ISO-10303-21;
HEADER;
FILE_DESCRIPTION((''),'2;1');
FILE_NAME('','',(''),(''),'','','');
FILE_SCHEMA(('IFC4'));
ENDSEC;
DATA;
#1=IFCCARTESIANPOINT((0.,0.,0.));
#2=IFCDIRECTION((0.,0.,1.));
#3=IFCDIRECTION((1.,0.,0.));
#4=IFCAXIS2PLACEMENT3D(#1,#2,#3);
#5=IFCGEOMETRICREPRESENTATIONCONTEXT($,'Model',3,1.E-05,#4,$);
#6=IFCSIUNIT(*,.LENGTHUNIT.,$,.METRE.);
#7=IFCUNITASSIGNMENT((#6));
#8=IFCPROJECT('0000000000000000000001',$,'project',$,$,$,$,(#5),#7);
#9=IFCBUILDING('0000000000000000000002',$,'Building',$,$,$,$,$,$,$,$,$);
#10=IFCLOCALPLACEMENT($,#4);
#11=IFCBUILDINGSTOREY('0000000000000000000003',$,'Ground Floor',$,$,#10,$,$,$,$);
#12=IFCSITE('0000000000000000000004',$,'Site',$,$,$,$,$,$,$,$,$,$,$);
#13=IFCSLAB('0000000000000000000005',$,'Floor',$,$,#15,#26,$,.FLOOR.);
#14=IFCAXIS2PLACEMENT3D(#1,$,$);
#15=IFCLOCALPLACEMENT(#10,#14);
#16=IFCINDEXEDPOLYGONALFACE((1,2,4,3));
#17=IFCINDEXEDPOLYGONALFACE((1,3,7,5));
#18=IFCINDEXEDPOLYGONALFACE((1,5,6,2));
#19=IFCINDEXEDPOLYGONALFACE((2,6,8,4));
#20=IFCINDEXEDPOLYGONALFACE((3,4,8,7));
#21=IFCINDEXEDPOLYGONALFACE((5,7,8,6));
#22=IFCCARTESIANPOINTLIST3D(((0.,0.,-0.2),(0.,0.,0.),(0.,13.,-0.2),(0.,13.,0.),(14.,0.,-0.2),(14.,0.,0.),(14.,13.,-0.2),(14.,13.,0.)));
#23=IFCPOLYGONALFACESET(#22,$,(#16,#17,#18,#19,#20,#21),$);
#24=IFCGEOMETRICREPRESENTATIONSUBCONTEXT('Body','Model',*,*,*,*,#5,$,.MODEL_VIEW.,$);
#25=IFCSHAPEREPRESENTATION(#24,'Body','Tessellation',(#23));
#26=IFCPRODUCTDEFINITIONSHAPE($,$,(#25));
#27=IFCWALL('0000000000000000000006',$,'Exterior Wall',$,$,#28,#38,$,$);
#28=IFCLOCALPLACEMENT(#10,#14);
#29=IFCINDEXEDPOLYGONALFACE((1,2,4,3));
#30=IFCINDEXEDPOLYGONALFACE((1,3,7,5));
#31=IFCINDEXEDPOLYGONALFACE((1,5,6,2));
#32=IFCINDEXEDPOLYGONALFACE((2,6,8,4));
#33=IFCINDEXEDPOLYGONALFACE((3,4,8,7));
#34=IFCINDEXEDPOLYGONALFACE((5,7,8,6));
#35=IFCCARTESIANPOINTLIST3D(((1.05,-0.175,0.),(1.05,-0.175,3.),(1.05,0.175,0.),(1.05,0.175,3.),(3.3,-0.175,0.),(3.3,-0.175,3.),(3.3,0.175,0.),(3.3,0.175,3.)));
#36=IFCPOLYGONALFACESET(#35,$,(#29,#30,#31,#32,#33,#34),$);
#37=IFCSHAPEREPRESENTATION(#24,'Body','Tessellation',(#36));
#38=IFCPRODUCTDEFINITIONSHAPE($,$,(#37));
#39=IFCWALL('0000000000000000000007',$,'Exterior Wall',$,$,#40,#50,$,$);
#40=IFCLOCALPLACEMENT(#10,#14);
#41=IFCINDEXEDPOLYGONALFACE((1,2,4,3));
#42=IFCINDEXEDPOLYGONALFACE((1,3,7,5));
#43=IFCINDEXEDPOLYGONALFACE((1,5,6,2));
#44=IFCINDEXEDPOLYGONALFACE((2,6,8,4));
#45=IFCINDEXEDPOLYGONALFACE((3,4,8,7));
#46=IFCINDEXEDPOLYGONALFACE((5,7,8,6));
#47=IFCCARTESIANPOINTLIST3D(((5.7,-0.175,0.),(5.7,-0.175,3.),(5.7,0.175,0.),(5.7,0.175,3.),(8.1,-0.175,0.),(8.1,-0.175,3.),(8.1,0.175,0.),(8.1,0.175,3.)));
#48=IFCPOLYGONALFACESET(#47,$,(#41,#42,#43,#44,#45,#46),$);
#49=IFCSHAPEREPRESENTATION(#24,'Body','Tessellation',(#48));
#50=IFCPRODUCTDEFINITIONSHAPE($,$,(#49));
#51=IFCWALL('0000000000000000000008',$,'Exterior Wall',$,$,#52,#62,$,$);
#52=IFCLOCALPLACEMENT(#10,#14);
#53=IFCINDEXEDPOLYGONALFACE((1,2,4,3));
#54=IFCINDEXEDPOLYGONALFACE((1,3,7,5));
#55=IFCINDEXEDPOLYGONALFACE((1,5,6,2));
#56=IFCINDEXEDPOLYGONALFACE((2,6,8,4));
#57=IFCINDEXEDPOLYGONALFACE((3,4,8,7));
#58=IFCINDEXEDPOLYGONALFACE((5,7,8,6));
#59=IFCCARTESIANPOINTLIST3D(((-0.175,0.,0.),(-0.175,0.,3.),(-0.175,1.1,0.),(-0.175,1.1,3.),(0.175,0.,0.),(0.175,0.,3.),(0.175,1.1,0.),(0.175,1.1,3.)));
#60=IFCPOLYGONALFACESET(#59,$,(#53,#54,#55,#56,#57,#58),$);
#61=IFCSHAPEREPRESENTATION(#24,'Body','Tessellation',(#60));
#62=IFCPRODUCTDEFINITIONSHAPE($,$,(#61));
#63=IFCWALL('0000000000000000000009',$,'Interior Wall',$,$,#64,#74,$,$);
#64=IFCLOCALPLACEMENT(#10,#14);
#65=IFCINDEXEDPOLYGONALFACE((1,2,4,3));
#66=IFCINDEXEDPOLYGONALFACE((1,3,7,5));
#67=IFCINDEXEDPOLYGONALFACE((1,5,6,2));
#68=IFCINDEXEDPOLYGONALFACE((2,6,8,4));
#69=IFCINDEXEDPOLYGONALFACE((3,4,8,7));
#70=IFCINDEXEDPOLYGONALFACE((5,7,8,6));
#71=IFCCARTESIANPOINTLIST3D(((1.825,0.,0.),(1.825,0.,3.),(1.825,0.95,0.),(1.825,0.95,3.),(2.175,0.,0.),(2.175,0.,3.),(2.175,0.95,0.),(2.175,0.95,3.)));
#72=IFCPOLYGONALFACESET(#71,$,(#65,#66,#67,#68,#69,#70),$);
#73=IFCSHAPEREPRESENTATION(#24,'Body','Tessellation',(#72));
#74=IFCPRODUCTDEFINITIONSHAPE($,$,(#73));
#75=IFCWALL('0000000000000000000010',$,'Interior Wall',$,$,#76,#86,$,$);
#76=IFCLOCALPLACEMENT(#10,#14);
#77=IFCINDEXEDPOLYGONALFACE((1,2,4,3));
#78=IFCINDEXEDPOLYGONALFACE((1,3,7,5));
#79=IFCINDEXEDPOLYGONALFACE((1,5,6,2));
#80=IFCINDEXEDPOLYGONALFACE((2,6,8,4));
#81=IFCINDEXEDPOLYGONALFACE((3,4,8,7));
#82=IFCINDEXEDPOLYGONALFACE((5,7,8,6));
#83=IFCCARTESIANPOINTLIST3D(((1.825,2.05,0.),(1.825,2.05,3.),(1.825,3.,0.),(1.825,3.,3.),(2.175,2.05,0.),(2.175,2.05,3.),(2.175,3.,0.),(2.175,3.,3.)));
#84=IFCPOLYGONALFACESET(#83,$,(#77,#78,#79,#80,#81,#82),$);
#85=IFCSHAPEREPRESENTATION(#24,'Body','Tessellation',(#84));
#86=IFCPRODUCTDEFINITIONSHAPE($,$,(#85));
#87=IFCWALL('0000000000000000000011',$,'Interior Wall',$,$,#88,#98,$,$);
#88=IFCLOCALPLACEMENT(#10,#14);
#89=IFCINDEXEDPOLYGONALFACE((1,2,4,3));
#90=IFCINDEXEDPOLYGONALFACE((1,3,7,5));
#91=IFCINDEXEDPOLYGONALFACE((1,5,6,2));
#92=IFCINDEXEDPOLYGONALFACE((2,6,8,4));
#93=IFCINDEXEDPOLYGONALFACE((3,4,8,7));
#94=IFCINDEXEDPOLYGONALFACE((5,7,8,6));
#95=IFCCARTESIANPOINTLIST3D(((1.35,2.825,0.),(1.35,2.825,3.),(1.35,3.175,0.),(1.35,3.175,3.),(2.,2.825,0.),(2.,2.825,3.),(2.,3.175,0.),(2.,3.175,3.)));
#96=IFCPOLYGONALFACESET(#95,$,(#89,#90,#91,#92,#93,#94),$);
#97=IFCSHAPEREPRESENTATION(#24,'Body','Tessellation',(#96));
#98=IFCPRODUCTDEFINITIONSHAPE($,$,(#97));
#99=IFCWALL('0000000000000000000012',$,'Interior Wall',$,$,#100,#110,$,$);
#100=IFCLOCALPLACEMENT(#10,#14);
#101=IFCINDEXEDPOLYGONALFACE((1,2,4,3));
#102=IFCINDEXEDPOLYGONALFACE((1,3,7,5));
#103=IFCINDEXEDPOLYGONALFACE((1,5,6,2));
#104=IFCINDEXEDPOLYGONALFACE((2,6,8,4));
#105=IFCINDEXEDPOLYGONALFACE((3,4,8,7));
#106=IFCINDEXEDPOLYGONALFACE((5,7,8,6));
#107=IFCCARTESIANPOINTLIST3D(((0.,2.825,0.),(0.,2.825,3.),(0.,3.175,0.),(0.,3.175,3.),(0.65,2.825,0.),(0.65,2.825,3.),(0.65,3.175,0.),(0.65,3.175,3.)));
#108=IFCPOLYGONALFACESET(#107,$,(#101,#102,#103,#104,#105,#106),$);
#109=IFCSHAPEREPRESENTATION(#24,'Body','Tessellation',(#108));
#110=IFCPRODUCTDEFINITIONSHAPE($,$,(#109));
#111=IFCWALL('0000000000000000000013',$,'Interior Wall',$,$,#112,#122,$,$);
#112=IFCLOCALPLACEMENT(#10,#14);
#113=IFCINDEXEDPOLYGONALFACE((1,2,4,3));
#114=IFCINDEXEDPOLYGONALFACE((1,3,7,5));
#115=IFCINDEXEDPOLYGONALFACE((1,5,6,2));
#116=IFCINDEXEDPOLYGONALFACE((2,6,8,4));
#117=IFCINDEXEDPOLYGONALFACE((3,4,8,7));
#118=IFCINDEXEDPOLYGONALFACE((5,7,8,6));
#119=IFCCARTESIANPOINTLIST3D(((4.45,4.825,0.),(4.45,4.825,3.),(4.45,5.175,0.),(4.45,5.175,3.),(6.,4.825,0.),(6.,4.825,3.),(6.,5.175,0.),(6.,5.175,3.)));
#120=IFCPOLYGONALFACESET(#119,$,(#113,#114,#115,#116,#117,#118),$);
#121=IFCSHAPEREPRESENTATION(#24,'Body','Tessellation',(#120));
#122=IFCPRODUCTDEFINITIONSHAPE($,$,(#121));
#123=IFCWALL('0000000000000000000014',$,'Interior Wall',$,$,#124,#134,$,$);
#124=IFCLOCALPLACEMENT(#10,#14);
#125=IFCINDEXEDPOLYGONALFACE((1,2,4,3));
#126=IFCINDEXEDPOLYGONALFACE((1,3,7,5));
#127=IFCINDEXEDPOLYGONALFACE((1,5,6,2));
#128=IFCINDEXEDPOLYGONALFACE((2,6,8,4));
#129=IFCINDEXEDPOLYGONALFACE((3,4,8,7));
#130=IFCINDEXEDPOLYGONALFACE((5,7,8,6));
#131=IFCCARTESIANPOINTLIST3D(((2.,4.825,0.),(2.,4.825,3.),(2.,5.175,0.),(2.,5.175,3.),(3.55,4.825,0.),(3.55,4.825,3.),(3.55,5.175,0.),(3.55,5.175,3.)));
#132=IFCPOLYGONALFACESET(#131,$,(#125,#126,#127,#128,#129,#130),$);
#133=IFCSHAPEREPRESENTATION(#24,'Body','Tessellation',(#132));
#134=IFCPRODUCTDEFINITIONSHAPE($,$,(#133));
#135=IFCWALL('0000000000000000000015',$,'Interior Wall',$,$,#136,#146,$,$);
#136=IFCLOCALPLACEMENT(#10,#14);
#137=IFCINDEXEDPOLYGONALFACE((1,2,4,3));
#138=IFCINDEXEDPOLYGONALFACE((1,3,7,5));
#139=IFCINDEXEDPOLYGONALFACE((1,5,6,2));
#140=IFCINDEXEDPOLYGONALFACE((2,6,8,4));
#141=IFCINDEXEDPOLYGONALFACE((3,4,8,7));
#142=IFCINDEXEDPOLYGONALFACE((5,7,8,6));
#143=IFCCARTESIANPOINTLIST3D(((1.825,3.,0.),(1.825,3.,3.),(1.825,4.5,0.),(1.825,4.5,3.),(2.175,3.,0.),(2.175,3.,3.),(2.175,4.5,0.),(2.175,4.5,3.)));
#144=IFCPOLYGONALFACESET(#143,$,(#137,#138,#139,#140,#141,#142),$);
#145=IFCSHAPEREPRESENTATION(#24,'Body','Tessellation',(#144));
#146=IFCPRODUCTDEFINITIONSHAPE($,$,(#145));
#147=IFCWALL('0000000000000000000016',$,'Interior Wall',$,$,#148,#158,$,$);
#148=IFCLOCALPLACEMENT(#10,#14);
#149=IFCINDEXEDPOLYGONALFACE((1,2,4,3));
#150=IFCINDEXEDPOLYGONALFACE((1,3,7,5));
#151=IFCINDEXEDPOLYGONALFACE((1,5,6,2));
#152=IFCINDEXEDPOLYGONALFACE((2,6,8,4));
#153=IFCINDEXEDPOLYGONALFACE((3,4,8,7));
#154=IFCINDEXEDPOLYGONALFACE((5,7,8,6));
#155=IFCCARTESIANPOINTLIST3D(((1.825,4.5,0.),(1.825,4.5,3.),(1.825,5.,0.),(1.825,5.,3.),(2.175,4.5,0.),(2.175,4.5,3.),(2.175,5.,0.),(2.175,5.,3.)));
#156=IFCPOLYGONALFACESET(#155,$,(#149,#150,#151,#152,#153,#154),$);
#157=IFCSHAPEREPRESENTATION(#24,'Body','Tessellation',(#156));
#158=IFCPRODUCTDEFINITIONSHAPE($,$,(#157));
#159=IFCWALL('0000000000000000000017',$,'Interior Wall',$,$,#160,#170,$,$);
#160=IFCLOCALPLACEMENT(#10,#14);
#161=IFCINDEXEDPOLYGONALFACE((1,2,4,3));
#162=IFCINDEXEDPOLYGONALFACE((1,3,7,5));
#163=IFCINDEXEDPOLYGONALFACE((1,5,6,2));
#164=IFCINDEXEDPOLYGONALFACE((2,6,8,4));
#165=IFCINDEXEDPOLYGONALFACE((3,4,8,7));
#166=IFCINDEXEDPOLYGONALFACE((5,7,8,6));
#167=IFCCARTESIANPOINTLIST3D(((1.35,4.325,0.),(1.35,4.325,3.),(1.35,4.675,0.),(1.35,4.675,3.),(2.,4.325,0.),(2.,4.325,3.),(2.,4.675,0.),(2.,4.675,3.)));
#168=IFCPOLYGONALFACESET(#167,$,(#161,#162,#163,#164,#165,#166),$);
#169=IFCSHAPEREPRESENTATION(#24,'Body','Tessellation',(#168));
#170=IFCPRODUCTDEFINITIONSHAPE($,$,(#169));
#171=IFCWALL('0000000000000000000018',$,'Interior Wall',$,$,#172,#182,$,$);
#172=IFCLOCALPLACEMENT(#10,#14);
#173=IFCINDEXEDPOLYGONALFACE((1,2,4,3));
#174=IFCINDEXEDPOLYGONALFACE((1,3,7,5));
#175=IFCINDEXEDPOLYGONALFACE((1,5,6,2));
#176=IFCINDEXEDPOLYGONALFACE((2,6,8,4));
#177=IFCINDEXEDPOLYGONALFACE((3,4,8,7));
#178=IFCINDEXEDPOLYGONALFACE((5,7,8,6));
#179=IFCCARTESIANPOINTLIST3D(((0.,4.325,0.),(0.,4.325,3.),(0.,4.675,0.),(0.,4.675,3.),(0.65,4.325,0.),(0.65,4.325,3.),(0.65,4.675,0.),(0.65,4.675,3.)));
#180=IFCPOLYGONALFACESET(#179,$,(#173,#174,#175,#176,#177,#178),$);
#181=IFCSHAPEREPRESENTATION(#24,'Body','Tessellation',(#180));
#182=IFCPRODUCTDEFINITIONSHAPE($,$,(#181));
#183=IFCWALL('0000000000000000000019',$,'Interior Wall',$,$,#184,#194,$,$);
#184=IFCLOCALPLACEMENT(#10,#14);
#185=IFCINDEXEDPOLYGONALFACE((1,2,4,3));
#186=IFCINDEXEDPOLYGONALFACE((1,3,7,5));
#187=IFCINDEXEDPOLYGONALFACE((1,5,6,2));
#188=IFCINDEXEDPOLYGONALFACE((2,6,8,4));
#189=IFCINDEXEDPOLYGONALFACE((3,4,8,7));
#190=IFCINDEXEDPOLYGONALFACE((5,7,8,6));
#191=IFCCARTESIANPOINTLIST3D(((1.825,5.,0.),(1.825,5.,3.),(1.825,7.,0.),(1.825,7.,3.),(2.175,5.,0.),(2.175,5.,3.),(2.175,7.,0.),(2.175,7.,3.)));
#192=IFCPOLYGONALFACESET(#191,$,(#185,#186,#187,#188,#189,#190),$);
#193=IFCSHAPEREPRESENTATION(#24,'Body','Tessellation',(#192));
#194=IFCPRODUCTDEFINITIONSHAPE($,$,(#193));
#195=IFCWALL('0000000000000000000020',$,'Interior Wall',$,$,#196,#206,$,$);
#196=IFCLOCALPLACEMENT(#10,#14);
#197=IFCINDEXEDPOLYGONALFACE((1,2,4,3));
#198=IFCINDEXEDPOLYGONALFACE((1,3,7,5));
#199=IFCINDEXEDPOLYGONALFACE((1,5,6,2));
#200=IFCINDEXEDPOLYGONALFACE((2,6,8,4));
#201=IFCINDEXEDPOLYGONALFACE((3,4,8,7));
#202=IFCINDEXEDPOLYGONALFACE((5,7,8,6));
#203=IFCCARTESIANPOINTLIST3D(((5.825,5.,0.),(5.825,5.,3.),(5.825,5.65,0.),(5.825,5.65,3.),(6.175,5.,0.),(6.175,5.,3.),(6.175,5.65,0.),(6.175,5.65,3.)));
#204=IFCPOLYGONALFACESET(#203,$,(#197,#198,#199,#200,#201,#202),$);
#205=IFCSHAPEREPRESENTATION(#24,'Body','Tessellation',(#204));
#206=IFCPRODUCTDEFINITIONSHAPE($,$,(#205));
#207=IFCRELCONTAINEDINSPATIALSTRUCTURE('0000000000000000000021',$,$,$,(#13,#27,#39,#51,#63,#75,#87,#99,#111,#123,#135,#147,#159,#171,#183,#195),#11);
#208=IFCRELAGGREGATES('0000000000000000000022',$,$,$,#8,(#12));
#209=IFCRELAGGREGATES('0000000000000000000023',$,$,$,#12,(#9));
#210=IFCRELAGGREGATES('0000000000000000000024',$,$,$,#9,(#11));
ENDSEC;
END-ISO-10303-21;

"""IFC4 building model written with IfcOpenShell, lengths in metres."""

from ifc_helpers import new_model, si_unit, frame, origin_with_axes, place, context, subcontext, project, spatial, indexed_curve, outline, extrude, element, save


model = new_model("IFC4")

# Units and contexts
model_context = context("Model", 3, precision=1e-05, world=origin_with_axes())
body_context = subcontext(model_context, "Body", "Model", "MODEL_VIEW")
ifc_project = project(units=[si_unit("LENGTHUNIT", "METRE")], contexts=[model_context])

# Site, building, storey
site = spatial("IfcSite", under=ifc_project, Name="Site")
building = spatial("IfcBuilding", under=site, Name="Building")
storey_placement = place(None, origin_with_axes())
storey = spatial("IfcBuildingStorey", under=building, at=storey_placement, Name="Ground Floor")

# Slab
slab_placement = place(storey_placement, frame((0.0, 0.0, -0.2), z_axis=(0.0, 0.0, 1.0), x_axis=(1.0, 0.0, 0.0)))
element("IfcSlab", 1, at=slab_placement, inside=storey, Name="Floor", PredefinedType="FLOOR", context=body_context, shape_type="SweptSolid", body=[
    extrude(outline(indexed_curve([(0.0, 0.0), (14.0, 0.0), (14.0, 13.0), (0.0, 13.0)])), None, (0.0, 0.0, 1.0), 0.2),
])

# Walls
wall_1_placement = place(storey_placement, frame((1.05, 0.0, 0.0), z_axis=(0.0, 0.0, 1.0), x_axis=(1.0, 0.0, 0.0)))
element("IfcWall", 2, at=wall_1_placement, inside=storey, Name="Exterior Wall", context=body_context, shape_type="SweptSolid", body=[
    extrude(outline(indexed_curve([(0.0, 0.0), (0.0, 0.35), (2.25, 0.35), (2.25, 0.0), (0.0, 0.0)], self_intersect=False)), frame((0.0, -0.175, 0.0), z_axis=(0.0, 0.0, 1.0), x_axis=(1.0, 0.0, 0.0)), (0.0, 0.0, 1.0), 3.0),
])
wall_2_placement = place(storey_placement, frame((5.7, 0.0, 0.0), z_axis=(0.0, 0.0, 1.0), x_axis=(1.0, 0.0, 0.0)))
element("IfcWall", 3, at=wall_2_placement, inside=storey, Name="Exterior Wall", context=body_context, shape_type="SweptSolid", body=[
    extrude(outline(indexed_curve([(0.0, 0.0), (0.0, 0.35), (2.4, 0.35), (2.4, 0.0), (0.0, 0.0)], self_intersect=False)), frame((0.0, -0.175, 0.0), z_axis=(0.0, 0.0, 1.0), x_axis=(1.0, 0.0, 0.0)), (0.0, 0.0, 1.0), 3.0),
])
wall_3_placement = place(storey_placement, frame((0.0, 1.1, 0.0), z_axis=(0.0, 0.0, 1.0), x_axis=(0.0, -1.0, 0.0)))
element("IfcWall", 4, at=wall_3_placement, inside=storey, Name="Exterior Wall", context=body_context, shape_type="SweptSolid", body=[
    extrude(outline(indexed_curve([(0.0, 0.0), (0.0, 0.35), (1.1, 0.35), (1.1, 0.0), (0.0, 0.0)], self_intersect=False)), frame((0.0, -0.175, 0.0), z_axis=(0.0, 0.0, 1.0), x_axis=(1.0, 0.0, 0.0)), (0.0, 0.0, 1.0), 3.0),
])
wall_4_placement = place(storey_placement, frame((2.0, 0.0, 0.0), z_axis=(0.0, 0.0, 1.0), x_axis=(0.0, 1.0, 0.0)))
element("IfcWall", 5, at=wall_4_placement, inside=storey, Name="Interior Wall", context=body_context, shape_type="SweptSolid", body=[
    extrude(outline(indexed_curve([(0.0, 0.0), (0.0, 0.35), (0.95, 0.35), (0.95, 0.0), (0.0, 0.0)], self_intersect=False)), frame((0.0, -0.175, 0.0), z_axis=(0.0, 0.0, 1.0), x_axis=(1.0, 0.0, 0.0)), (0.0, 0.0, 1.0), 3.0),
])
wall_5_placement = place(storey_placement, frame((2.0, 2.05, 0.0), z_axis=(0.0, 0.0, 1.0), x_axis=(0.0, 1.0, 0.0)))
element("IfcWall", 6, at=wall_5_placement, inside=storey, Name="Interior Wall", context=body_context, shape_type="SweptSolid", body=[
    extrude(outline(indexed_curve([(0.0, 0.0), (0.0, 0.35), (0.95, 0.35), (0.95, 0.0), (0.0, 0.0)], self_intersect=False)), frame((0.0, -0.175, 0.0), z_axis=(0.0, 0.0, 1.0), x_axis=(1.0, 0.0, 0.0)), (0.0, 0.0, 1.0), 3.0),
])
for number, where, z_axis, x_axis, name in (
    (7, (2.0, 3.0, 0.0), (0.0, 0.0, 1.0), (-1.0, 0.0, 0.0), "Interior Wall"),
    (8, (0.65, 3.0, 0.0), (0.0, 0.0, 1.0), (-1.0, 0.0, 0.0), "Interior Wall"),
):
    element("IfcWall", number, at=place(storey_placement, frame(where, z_axis=z_axis, x_axis=x_axis)), inside=storey, Name=name, context=body_context, shape_type="SweptSolid", body=[
        extrude(outline(indexed_curve([(0.0, 0.0), (0.0, 0.35), (0.65, 0.35), (0.65, 0.0), (0.0, 0.0)], self_intersect=False)), frame((0.0, -0.175, 0.0), z_axis=(0.0, 0.0, 1.0), x_axis=(1.0, 0.0, 0.0)), (0.0, 0.0, 1.0), 3.0),
    ])
for number, where, z_axis, x_axis, name in (
    (9, (6.0, 5.0, 0.0), (0.0, 0.0, 1.0), (-1.0, 0.0, 0.0), "Interior Wall"),
    (10, (3.55, 5.0, 0.0), (0.0, 0.0, 1.0), (-1.0, 0.0, 0.0), "Interior Wall"),
):
    element("IfcWall", number, at=place(storey_placement, frame(where, z_axis=z_axis, x_axis=x_axis)), inside=storey, Name=name, context=body_context, shape_type="SweptSolid", body=[
        extrude(outline(indexed_curve([(0.0, 0.0), (0.0, 0.35), (1.55, 0.35), (1.55, 0.0), (0.0, 0.0)], self_intersect=False)), frame((0.0, -0.175, 0.0), z_axis=(0.0, 0.0, 1.0), x_axis=(1.0, 0.0, 0.0)), (0.0, 0.0, 1.0), 3.0),
    ])
wall_6_placement = place(storey_placement, frame((2.0, 4.5, 0.0), z_axis=(0.0, 0.0, 1.0), x_axis=(0.0, -1.0, 0.0)))
element("IfcWall", 11, at=wall_6_placement, inside=storey, Name="Interior Wall", context=body_context, shape_type="SweptSolid", body=[
    extrude(outline(indexed_curve([(0.0, 0.0), (0.0, 0.35), (1.5, 0.35), (1.5, 0.0), (0.0, 0.0)], self_intersect=False)), frame((0.0, -0.175, 0.0), z_axis=(0.0, 0.0, 1.0), x_axis=(1.0, 0.0, 0.0)), (0.0, 0.0, 1.0), 3.0),
])
wall_7_placement = place(storey_placement, frame((2.0, 5.0, 0.0), z_axis=(0.0, 0.0, 1.0), x_axis=(0.0, -1.0, 0.0)))
element("IfcWall", 12, at=wall_7_placement, inside=storey, Name="Interior Wall", context=body_context, shape_type="SweptSolid", body=[
    extrude(outline(indexed_curve([(0.0, 0.0), (0.0, 0.35), (0.5, 0.35), (0.5, 0.0), (0.0, 0.0)], self_intersect=False)), frame((0.0, -0.175, 0.0), z_axis=(0.0, 0.0, 1.0), x_axis=(1.0, 0.0, 0.0)), (0.0, 0.0, 1.0), 3.0),
])
for number, where, z_axis, x_axis, name in (
    (13, (2.0, 4.5, 0.0), (0.0, 0.0, 1.0), (-1.0, 0.0, 0.0), "Interior Wall"),
    (14, (0.65, 4.5, 0.0), (0.0, 0.0, 1.0), (-1.0, 0.0, 0.0), "Interior Wall"),
):
    element("IfcWall", number, at=place(storey_placement, frame(where, z_axis=z_axis, x_axis=x_axis)), inside=storey, Name=name, context=body_context, shape_type="SweptSolid", body=[
        extrude(outline(indexed_curve([(0.0, 0.0), (0.0, 0.35), (0.65, 0.35), (0.65, 0.0), (0.0, 0.0)], self_intersect=False)), frame((0.0, -0.175, 0.0), z_axis=(0.0, 0.0, 1.0), x_axis=(1.0, 0.0, 0.0)), (0.0, 0.0, 1.0), 3.0),
    ])
wall_8_placement = place(storey_placement, frame((2.0, 5.0, 0.0), z_axis=(0.0, 0.0, 1.0), x_axis=(0.0, 1.0, 0.0)))
element("IfcWall", 15, at=wall_8_placement, inside=storey, Name="Interior Wall", context=body_context, shape_type="SweptSolid", body=[
    extrude(outline(indexed_curve([(0.0, 0.0), (0.0, 0.35), (2.0, 0.35), (2.0, 0.0), (0.0, 0.0)], self_intersect=False)), frame((0.0, -0.175, 0.0), z_axis=(0.0, 0.0, 1.0), x_axis=(1.0, 0.0, 0.0)), (0.0, 0.0, 1.0), 3.0),
])
wall_9_placement = place(storey_placement, frame((6.0, 5.0, 0.0), z_axis=(0.0, 0.0, 1.0), x_axis=(0.0, 1.0, 0.0)))
element("IfcWall", 16, at=wall_9_placement, inside=storey, Name="Interior Wall", context=body_context, shape_type="SweptSolid", body=[
    extrude(outline(indexed_curve([(0.0, 0.0), (0.0, 0.35), (0.65, 0.35), (0.65, 0.0), (0.0, 0.0)], self_intersect=False)), frame((0.0, -0.175, 0.0), z_axis=(0.0, 0.0, 1.0), x_axis=(1.0, 0.0, 0.0)), (0.0, 0.0, 1.0), 3.0),
])

save(model, "model.ifc")
